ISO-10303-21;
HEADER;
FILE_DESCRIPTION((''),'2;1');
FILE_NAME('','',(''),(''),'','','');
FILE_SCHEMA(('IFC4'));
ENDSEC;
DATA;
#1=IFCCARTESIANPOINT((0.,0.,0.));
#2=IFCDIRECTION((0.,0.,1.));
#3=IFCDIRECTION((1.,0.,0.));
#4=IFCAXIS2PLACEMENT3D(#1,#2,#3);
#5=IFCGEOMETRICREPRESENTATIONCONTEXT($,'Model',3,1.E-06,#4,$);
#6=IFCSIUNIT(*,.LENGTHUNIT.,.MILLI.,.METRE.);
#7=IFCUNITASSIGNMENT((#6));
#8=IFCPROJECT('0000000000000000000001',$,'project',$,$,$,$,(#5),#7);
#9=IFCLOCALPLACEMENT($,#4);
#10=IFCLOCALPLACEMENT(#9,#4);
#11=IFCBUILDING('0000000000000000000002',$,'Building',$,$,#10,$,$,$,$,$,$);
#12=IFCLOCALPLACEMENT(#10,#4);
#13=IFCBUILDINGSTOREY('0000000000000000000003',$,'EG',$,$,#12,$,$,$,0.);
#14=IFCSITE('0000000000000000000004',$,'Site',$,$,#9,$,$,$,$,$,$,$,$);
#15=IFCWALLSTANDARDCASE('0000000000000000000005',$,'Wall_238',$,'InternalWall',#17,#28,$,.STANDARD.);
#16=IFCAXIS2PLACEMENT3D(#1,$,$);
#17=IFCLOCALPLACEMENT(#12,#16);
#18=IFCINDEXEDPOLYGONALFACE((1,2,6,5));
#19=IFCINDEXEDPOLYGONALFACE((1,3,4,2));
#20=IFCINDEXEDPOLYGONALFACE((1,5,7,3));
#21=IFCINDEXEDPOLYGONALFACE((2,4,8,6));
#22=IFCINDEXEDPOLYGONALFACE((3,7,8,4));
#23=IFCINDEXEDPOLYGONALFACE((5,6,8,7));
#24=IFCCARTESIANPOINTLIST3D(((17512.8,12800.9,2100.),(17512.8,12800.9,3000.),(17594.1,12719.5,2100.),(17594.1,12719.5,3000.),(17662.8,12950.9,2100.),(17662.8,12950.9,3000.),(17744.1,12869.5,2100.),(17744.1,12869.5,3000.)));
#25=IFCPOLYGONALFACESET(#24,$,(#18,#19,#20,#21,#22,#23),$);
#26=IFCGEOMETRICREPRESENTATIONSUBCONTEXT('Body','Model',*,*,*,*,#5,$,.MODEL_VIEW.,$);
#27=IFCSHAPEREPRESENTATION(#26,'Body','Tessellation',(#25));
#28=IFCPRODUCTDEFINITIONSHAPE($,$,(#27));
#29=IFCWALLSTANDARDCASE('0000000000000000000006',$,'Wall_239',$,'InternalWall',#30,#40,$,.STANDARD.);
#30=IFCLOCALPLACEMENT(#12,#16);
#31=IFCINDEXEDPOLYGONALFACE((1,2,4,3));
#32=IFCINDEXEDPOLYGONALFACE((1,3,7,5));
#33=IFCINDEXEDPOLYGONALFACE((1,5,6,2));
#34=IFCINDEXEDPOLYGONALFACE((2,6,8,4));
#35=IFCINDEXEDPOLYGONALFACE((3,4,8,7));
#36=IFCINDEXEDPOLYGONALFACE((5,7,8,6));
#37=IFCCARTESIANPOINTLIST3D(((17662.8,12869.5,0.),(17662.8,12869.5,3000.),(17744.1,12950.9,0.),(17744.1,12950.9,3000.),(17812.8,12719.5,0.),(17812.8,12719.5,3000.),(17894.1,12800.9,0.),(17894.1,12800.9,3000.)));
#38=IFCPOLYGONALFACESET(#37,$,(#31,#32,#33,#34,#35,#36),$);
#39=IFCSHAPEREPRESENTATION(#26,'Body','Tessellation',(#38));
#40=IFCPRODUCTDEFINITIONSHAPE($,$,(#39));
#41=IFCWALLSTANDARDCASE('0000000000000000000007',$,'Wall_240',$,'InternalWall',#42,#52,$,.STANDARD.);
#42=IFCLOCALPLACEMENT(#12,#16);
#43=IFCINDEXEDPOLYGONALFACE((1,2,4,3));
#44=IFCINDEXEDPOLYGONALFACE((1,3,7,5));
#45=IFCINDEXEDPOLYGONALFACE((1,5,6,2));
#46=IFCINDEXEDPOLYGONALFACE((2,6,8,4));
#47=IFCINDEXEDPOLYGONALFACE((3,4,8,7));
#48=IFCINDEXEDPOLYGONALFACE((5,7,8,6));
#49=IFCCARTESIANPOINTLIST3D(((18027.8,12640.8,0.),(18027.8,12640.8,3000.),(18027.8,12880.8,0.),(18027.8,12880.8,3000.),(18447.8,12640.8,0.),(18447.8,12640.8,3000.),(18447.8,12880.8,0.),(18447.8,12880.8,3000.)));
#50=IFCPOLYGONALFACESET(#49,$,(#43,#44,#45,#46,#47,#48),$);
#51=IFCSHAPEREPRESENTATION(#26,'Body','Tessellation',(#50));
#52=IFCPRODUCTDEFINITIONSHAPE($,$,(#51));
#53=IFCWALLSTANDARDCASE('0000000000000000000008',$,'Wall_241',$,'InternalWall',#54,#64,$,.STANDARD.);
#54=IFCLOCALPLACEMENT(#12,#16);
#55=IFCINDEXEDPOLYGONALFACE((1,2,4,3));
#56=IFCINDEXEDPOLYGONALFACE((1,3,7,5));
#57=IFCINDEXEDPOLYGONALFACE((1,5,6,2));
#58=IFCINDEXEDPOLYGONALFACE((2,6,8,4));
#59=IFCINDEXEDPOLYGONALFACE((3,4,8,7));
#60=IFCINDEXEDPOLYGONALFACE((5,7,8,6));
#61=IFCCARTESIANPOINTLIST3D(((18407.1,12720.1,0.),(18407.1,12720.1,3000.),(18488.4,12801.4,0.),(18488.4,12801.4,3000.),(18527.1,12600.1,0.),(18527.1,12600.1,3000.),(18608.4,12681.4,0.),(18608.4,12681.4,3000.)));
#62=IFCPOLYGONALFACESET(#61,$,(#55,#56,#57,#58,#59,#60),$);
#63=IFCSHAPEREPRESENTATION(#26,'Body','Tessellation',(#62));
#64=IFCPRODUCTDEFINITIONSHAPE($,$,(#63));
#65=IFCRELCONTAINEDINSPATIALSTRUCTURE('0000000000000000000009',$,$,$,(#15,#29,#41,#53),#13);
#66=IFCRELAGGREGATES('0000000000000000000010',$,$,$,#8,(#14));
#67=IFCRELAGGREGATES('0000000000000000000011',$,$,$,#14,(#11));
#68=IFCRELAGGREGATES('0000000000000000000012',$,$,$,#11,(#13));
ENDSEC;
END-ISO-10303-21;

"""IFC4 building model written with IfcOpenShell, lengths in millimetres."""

from ifc_helpers import new_model, si_unit, frame, origin_with_axes, place, context, subcontext, project, spatial, rectangle, extrude, element, save


model = new_model("IFC4")

# Units and contexts
model_context = context("Model", 3, precision=1e-06, world=origin_with_axes())
body_context = subcontext(model_context, "Body", "Model", "MODEL_VIEW")
ifc_project = project(units=[si_unit("LENGTHUNIT", "METRE", prefix="MILLI")], contexts=[model_context])

# Site, building, storey
site_placement = place(None, origin_with_axes())
site = spatial("IfcSite", under=ifc_project, at=site_placement, Name="Site")
building_placement = place(site_placement, origin_with_axes())
building = spatial("IfcBuilding", under=site, at=building_placement, Name="Building")
storey_placement = place(building_placement, origin_with_axes())
storey = spatial("IfcBuildingStorey", under=building, at=storey_placement, Name="EG", Elevation=0.0)

# Wall, opening
wall_1_placement = place(storey_placement, origin_with_axes())
wall_1 = element("IfcWallStandardCase", 1, at=wall_1_placement, inside=storey, Name="Wall_238", ObjectType="InternalWall", PredefinedType="STANDARD", context=body_context, shape_type="SweptSolid", body=[
    extrude(rectangle(XDim=212.1, YDim=115.0), frame((17628.4, 12835.2, 0.0), z_axis=(0.0, 0.0, 1.0), x_axis=(-0.707107, -0.707107, 0.0)), (0.0, 0.0, 1.0), 3000.0),
])
opening_1_placement = place(wall_1_placement, origin_with_axes())
element("IfcOpeningElement", 2, at=opening_1_placement, inside=storey, cuts=wall_1, context=body_context, shape_type="SweptSolid", body=[
    extrude(rectangle(XDim=1405.8, YDim=115.0), frame((17394.4, 12601.2, 0.0), z_axis=(0.0, 0.0, 1.0), x_axis=(-0.707107, -0.707107, 0.0)), (0.0, 0.0, 1.0), 2100.0),
])

# Walls
wall_2_placement = place(storey_placement, origin_with_axes())
element("IfcWallStandardCase", 3, at=wall_2_placement, inside=storey, Name="Wall_239", ObjectType="InternalWall", PredefinedType="STANDARD", context=body_context, shape_type="SweptSolid", body=[
    extrude(rectangle(XDim=212.1, YDim=115.0), frame((17778.4, 12835.2, 0.0), z_axis=(0.0, 0.0, 1.0), x_axis=(0.707107, -0.707107, 0.0)), (0.0, 0.0, 1.0), 3000.0),
])
wall_3_placement = place(storey_placement, origin_with_axes())
element("IfcWallStandardCase", 4, at=wall_3_placement, inside=storey, Name="Wall_240", ObjectType="InternalWall", PredefinedType="STANDARD", context=body_context, shape_type="SweptSolid", body=[
    extrude(rectangle(XDim=420.0, YDim=240.0), frame((18237.8, 12760.8, 0.0), z_axis=(0.0, 0.0, 1.0), x_axis=(-1.0, 0.0, 0.0)), (0.0, 0.0, 1.0), 3000.0),
])
wall_4_placement = place(storey_placement, origin_with_axes())
element("IfcWallStandardCase", 5, at=wall_4_placement, inside=storey, Name="Wall_241", ObjectType="InternalWall", PredefinedType="STANDARD", context=body_context, shape_type="SweptSolid", body=[
    extrude(rectangle(XDim=169.7, YDim=115.0), frame((18507.8, 12700.8, 0.0), z_axis=(0.0, 0.0, 1.0), x_axis=(0.707107, -0.707107, 0.0)), (0.0, 0.0, 1.0), 3000.0),
])

save(model, "model.ifc")
